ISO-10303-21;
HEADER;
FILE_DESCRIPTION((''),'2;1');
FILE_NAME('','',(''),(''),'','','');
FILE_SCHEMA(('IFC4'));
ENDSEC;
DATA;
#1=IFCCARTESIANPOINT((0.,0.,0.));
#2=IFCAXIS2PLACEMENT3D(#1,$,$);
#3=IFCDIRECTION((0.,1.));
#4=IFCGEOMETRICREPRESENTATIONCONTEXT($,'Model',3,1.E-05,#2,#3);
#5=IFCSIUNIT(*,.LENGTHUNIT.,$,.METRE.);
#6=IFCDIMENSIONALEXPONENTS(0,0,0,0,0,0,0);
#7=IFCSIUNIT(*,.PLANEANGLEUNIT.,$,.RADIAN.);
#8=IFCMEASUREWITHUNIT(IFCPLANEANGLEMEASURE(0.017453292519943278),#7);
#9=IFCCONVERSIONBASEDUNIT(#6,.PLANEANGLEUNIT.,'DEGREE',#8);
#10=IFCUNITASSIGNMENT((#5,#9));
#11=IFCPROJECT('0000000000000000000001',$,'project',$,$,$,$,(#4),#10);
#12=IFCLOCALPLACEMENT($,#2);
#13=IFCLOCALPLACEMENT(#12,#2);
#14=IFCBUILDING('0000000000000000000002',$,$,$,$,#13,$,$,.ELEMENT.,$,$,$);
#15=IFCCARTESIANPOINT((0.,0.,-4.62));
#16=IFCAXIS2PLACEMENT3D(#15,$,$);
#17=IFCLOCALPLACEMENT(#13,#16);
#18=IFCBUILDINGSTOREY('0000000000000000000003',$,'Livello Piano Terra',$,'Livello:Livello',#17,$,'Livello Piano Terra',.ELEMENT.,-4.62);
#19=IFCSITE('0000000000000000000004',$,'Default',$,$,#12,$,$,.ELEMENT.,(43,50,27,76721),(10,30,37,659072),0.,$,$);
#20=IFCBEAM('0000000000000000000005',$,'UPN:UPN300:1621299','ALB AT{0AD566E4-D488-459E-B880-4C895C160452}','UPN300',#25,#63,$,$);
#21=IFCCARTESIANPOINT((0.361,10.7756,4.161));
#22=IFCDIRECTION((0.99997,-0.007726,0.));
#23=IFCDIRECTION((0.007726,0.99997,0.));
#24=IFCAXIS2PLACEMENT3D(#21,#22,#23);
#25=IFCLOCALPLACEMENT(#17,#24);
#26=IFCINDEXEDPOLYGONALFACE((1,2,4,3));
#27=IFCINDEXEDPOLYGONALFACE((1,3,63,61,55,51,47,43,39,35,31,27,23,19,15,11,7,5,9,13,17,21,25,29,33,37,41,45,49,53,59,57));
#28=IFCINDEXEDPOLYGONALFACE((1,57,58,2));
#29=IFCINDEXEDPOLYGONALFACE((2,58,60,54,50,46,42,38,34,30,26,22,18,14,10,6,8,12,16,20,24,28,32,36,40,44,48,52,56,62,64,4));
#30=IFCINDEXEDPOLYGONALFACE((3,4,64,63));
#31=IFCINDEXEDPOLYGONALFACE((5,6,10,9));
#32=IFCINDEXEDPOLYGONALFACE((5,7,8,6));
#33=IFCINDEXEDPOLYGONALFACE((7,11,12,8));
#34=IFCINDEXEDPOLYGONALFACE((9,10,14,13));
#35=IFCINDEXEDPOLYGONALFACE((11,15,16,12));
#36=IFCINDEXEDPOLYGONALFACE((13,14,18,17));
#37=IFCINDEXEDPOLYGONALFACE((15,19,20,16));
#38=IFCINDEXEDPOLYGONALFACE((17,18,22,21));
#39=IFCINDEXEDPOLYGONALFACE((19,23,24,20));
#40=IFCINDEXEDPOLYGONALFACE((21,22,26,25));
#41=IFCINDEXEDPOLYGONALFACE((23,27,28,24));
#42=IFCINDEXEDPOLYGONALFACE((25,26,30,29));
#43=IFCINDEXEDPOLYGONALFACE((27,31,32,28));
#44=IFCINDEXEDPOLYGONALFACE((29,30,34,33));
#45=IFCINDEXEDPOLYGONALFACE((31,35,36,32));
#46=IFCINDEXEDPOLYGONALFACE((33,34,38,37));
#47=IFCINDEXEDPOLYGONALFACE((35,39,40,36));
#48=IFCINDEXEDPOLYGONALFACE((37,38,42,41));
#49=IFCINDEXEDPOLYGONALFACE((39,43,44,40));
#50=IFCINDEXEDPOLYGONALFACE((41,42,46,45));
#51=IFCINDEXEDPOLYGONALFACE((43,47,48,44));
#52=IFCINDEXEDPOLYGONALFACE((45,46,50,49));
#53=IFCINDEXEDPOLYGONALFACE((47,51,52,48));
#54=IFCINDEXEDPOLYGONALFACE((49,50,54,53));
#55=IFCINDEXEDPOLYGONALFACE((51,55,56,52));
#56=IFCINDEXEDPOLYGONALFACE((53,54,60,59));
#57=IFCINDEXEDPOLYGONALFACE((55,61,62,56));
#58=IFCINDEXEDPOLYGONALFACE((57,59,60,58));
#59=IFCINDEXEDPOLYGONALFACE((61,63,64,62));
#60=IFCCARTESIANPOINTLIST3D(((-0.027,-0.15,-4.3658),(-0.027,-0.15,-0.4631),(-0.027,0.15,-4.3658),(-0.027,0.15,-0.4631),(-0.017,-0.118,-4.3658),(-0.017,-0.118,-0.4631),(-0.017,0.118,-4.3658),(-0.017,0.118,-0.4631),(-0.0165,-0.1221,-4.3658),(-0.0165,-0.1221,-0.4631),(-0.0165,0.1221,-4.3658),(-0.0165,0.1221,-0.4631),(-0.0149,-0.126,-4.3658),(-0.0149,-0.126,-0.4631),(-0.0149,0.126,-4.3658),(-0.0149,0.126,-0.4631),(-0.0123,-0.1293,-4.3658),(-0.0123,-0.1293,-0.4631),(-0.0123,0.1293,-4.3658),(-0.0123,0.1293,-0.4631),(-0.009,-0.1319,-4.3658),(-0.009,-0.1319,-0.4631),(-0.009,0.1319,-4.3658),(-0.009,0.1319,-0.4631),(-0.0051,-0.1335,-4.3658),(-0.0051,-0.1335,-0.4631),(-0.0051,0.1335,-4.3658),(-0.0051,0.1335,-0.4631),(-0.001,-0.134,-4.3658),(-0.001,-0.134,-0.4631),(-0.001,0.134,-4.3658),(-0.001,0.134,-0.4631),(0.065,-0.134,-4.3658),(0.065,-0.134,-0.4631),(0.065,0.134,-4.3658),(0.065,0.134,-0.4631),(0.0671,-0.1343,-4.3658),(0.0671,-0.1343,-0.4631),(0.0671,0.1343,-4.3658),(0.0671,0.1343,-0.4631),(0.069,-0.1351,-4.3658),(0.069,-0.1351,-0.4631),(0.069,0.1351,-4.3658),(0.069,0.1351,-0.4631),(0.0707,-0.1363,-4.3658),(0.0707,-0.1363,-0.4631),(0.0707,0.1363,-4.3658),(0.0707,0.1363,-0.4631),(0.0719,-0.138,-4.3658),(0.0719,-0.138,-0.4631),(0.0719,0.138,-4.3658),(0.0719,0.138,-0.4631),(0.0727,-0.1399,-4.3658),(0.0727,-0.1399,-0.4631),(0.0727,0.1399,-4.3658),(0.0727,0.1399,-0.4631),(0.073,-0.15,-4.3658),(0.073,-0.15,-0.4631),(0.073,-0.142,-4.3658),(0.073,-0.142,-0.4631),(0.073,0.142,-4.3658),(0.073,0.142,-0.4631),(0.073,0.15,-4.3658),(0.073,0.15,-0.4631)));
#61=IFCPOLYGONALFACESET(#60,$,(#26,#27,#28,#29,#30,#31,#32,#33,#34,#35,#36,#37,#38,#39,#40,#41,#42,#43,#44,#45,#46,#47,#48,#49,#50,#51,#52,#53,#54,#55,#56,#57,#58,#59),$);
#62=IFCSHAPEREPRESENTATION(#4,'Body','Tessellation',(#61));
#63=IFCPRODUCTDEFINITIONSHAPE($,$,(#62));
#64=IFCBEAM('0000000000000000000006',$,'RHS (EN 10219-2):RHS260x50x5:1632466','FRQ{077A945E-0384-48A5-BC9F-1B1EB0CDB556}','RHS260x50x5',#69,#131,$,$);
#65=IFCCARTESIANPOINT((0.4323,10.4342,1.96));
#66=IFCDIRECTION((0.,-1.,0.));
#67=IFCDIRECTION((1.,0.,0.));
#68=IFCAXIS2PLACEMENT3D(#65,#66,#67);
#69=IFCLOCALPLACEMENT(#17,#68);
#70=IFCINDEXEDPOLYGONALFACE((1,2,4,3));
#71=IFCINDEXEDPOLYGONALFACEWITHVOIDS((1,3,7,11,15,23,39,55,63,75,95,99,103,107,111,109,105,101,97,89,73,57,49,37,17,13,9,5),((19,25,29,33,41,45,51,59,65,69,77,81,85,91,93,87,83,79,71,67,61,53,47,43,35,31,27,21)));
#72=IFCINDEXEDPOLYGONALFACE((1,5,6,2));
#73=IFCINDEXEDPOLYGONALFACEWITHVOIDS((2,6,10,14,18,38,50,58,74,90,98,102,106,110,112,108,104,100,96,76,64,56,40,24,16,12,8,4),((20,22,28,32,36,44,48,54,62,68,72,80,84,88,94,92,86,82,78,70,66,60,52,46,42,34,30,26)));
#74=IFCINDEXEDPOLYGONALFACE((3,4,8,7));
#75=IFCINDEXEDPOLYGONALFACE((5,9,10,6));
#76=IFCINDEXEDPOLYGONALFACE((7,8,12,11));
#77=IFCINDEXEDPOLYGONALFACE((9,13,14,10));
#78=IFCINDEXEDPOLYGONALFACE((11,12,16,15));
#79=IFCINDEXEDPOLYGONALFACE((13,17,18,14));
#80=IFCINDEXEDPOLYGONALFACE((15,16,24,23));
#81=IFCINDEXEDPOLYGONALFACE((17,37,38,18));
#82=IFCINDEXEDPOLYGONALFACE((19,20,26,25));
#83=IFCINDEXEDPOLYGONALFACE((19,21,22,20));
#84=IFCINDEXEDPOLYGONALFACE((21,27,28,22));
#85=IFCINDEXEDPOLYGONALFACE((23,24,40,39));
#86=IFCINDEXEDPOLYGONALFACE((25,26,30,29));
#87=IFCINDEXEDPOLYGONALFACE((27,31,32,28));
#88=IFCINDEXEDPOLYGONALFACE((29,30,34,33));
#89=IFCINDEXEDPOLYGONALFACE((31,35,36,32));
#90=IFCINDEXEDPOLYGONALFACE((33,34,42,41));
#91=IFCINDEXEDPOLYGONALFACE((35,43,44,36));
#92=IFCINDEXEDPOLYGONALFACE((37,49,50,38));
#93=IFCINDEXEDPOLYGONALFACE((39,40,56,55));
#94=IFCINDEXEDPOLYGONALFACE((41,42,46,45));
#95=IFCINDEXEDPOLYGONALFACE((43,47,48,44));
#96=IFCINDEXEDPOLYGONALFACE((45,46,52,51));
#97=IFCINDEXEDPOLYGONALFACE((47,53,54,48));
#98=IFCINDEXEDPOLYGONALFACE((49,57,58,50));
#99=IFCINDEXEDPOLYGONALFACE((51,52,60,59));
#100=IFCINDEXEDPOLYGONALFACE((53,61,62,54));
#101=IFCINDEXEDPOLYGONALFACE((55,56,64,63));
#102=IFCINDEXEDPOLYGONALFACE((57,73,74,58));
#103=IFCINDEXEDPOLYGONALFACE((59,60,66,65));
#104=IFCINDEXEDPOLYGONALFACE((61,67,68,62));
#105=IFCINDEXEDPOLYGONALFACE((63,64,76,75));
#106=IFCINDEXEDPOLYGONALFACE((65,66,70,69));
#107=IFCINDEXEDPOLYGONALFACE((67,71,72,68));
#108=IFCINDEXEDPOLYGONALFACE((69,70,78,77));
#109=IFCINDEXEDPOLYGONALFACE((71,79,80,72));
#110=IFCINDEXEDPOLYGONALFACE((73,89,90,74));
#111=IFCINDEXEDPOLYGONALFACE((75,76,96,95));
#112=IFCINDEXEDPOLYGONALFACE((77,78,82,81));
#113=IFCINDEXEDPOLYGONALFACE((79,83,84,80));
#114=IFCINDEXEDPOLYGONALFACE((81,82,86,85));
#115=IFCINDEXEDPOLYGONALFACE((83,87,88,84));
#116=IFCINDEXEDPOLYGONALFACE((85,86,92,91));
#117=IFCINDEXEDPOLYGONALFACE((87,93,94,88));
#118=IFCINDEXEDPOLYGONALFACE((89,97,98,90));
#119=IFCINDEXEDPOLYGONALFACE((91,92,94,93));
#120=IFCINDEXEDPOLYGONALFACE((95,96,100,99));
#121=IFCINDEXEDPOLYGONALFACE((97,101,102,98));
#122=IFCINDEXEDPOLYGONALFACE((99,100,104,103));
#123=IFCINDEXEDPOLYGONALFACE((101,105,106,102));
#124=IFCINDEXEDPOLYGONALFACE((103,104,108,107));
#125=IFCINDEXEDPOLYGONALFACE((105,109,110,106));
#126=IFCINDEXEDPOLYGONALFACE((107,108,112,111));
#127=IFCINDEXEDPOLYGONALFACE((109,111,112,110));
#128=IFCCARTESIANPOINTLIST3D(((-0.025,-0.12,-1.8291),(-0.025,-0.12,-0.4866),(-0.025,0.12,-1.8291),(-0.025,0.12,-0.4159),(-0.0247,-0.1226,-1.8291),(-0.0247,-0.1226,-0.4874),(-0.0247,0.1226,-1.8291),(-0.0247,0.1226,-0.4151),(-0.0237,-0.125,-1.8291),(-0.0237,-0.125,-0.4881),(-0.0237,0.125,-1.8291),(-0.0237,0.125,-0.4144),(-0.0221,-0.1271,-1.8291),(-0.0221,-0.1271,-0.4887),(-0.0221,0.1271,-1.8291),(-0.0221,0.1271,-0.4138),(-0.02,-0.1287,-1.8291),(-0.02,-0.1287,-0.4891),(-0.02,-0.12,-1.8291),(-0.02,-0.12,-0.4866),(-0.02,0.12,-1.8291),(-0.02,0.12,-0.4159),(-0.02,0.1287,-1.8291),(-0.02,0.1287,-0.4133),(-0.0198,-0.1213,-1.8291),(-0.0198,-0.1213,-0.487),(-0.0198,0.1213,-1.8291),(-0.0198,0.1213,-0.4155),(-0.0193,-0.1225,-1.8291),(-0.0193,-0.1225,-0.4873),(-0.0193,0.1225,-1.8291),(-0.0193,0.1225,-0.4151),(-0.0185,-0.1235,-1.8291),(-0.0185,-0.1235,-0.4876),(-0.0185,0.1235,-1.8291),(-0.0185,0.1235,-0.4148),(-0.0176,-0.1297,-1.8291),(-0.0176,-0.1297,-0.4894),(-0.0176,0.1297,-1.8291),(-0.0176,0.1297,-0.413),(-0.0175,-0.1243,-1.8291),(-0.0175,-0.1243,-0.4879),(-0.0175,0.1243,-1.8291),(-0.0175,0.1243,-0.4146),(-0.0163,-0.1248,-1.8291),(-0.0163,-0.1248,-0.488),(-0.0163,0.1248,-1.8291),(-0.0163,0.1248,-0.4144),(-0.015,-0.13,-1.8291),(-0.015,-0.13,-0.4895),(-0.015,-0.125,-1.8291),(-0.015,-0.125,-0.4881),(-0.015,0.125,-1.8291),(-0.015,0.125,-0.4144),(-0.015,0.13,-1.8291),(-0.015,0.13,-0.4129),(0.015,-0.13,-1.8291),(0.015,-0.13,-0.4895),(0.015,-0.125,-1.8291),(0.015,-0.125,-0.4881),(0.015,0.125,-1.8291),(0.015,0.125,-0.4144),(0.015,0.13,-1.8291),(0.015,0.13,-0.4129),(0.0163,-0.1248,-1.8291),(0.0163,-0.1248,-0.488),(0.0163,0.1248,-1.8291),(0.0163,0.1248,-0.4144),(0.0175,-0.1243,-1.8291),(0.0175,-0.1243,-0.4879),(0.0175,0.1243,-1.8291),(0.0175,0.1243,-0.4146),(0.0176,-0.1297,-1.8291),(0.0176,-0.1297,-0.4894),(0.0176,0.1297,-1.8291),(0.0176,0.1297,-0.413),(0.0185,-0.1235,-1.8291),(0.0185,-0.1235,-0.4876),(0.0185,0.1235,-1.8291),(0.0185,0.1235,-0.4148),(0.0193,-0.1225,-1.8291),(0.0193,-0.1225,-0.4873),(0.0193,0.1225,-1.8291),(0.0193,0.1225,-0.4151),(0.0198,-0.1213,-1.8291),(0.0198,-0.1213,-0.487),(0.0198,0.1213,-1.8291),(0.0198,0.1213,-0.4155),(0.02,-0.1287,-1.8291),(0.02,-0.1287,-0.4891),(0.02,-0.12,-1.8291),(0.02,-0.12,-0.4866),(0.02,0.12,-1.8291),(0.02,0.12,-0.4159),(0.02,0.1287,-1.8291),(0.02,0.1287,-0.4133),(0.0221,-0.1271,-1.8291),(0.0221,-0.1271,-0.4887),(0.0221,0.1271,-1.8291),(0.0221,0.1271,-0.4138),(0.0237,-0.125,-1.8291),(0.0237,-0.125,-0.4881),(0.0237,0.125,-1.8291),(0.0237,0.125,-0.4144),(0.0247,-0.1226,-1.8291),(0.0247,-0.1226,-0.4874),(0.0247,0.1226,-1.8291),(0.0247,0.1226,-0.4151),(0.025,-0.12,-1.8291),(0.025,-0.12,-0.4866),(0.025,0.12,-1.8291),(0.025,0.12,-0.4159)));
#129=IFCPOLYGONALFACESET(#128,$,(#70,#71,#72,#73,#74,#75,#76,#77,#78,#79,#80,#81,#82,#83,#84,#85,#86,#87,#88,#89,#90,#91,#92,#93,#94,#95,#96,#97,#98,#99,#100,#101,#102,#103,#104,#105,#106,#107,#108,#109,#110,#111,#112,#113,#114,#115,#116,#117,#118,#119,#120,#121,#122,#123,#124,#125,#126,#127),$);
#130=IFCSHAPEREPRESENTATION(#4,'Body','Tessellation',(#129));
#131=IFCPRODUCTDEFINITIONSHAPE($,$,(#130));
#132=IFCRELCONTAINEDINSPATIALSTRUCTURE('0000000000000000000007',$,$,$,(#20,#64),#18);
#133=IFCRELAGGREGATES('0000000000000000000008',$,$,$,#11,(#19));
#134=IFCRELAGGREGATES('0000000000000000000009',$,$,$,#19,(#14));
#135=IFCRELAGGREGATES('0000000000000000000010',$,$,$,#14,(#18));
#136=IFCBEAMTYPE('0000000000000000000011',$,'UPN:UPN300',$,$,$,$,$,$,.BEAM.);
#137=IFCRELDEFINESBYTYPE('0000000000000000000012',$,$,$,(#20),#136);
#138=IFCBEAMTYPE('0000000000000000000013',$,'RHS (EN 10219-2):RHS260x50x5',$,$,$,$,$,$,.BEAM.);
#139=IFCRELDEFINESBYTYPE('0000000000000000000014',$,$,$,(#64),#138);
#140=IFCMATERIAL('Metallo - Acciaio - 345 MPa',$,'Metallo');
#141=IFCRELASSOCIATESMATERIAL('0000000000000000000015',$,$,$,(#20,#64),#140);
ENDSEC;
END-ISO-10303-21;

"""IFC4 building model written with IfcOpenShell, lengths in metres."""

from ifc_helpers import new_model, entity, si_unit, converted_unit, direction, frame, frame_2d, origin, origin_2d, place, context, project, spatial, hollow_rectangle, u_section, extrude, clip, halfspace, material, type_object, element, save


model = new_model("IFC4")

# Units and contexts
model_context = context("Model", 3, precision=1e-05, world=origin(), true_north=direction((0.0, 1.0)))
ifc_project = project(units=[si_unit("LENGTHUNIT", "METRE"), converted_unit("PLANEANGLEUNIT", "DEGREE", entity("IfcPlaneAngleMeasure", 0.017453292519943278), si_unit("PLANEANGLEUNIT", "RADIAN"), dimensions=[0, 0, 0, 0, 0, 0, 0])], contexts=[model_context])

# Site, building, storey
site_placement = place(None, origin())
site = spatial("IfcSite", under=ifc_project, at=site_placement, Name="Default", CompositionType="ELEMENT", RefLatitude=(43, 50, 27, 76721), RefLongitude=(10, 30, 37, 659072), RefElevation=0.0)
building_placement = place(site_placement, origin())
building = spatial("IfcBuilding", under=site, at=building_placement, CompositionType="ELEMENT")
storey_placement = place(building_placement, frame((0.0, 0.0, -4.62)))
storey = spatial("IfcBuildingStorey", under=building, at=storey_placement, Name="Livello Piano Terra", ObjectType="Livello:Livello", LongName="Livello Piano Terra", CompositionType="ELEMENT", Elevation=-4.62)

# Beams
ifc_material_1 = material(Name="Metallo - Acciaio - 345 MPa", Category="Metallo")
beam_type_1 = type_object("IfcBeamType", Name="UPN:UPN300", PredefinedType="BEAM")
beam_1_placement = place(storey_placement, frame((0.361, 10.7756, 4.161), z_axis=(0.99997, -0.007726, 0.0), x_axis=(0.007726, 0.99997, 0.0)))
element("IfcBeam", 1, at=beam_1_placement, inside=storey, type_object=beam_type_1, material=ifc_material_1, Name="UPN:UPN300:1621299", Description="ALB AT{0AD566E4-D488-459E-B880-4C895C160452}", ObjectType="UPN300", context=model_context, shape_type="Clipping", body=[
    clip(extrude(u_section(Depth=0.3, FlangeWidth=0.1, WebThickness=0.01, FlangeThickness=0.016, FilletRadius=0.016, EdgeRadius=0.008, FlangeSlope=0.00457, at=frame_2d((0.023, 0.0))), origin(), (0.0, 0.0, -1.0), 4.3658), halfspace(frame((-10.7781, 0.459, -0.4631), z_axis=(0.0, 0.0, -1.0), x_axis=(-1.0, 0.0, 0.0)), True)),
])
beam_type_2 = type_object("IfcBeamType", Name="RHS (EN 10219-2):RHS260x50x5", PredefinedType="BEAM")
beam_2_placement = place(storey_placement, frame((0.4323, 10.4342, 1.96), z_axis=(0.0, -1.0, 0.0), x_axis=(1.0, 0.0, 0.0)))
element("IfcBeam", 2, at=beam_2_placement, inside=storey, type_object=beam_type_2, material=ifc_material_1, Name="RHS (EN 10219-2):RHS260x50x5:1632466", Description="FRQ{077A945E-0384-48A5-BC9F-1B1EB0CDB556}", ObjectType="RHS260x50x5", context=model_context, shape_type="Clipping", body=[
    clip(extrude(hollow_rectangle(XDim=0.05, YDim=0.26, WallThickness=0.005, InnerFilletRadius=0.005, OuterFilletRadius=0.01, at=origin_2d()), origin(), (0.0, 0.0, -1.0), 1.8291), halfspace(frame((-0.4044, 5.3992, 1.1398), z_axis=(0.0, 0.282661, -0.95922), x_axis=(-1.0, 0.0, 0.0)), True)),
])

save(model, "model.ifc")
